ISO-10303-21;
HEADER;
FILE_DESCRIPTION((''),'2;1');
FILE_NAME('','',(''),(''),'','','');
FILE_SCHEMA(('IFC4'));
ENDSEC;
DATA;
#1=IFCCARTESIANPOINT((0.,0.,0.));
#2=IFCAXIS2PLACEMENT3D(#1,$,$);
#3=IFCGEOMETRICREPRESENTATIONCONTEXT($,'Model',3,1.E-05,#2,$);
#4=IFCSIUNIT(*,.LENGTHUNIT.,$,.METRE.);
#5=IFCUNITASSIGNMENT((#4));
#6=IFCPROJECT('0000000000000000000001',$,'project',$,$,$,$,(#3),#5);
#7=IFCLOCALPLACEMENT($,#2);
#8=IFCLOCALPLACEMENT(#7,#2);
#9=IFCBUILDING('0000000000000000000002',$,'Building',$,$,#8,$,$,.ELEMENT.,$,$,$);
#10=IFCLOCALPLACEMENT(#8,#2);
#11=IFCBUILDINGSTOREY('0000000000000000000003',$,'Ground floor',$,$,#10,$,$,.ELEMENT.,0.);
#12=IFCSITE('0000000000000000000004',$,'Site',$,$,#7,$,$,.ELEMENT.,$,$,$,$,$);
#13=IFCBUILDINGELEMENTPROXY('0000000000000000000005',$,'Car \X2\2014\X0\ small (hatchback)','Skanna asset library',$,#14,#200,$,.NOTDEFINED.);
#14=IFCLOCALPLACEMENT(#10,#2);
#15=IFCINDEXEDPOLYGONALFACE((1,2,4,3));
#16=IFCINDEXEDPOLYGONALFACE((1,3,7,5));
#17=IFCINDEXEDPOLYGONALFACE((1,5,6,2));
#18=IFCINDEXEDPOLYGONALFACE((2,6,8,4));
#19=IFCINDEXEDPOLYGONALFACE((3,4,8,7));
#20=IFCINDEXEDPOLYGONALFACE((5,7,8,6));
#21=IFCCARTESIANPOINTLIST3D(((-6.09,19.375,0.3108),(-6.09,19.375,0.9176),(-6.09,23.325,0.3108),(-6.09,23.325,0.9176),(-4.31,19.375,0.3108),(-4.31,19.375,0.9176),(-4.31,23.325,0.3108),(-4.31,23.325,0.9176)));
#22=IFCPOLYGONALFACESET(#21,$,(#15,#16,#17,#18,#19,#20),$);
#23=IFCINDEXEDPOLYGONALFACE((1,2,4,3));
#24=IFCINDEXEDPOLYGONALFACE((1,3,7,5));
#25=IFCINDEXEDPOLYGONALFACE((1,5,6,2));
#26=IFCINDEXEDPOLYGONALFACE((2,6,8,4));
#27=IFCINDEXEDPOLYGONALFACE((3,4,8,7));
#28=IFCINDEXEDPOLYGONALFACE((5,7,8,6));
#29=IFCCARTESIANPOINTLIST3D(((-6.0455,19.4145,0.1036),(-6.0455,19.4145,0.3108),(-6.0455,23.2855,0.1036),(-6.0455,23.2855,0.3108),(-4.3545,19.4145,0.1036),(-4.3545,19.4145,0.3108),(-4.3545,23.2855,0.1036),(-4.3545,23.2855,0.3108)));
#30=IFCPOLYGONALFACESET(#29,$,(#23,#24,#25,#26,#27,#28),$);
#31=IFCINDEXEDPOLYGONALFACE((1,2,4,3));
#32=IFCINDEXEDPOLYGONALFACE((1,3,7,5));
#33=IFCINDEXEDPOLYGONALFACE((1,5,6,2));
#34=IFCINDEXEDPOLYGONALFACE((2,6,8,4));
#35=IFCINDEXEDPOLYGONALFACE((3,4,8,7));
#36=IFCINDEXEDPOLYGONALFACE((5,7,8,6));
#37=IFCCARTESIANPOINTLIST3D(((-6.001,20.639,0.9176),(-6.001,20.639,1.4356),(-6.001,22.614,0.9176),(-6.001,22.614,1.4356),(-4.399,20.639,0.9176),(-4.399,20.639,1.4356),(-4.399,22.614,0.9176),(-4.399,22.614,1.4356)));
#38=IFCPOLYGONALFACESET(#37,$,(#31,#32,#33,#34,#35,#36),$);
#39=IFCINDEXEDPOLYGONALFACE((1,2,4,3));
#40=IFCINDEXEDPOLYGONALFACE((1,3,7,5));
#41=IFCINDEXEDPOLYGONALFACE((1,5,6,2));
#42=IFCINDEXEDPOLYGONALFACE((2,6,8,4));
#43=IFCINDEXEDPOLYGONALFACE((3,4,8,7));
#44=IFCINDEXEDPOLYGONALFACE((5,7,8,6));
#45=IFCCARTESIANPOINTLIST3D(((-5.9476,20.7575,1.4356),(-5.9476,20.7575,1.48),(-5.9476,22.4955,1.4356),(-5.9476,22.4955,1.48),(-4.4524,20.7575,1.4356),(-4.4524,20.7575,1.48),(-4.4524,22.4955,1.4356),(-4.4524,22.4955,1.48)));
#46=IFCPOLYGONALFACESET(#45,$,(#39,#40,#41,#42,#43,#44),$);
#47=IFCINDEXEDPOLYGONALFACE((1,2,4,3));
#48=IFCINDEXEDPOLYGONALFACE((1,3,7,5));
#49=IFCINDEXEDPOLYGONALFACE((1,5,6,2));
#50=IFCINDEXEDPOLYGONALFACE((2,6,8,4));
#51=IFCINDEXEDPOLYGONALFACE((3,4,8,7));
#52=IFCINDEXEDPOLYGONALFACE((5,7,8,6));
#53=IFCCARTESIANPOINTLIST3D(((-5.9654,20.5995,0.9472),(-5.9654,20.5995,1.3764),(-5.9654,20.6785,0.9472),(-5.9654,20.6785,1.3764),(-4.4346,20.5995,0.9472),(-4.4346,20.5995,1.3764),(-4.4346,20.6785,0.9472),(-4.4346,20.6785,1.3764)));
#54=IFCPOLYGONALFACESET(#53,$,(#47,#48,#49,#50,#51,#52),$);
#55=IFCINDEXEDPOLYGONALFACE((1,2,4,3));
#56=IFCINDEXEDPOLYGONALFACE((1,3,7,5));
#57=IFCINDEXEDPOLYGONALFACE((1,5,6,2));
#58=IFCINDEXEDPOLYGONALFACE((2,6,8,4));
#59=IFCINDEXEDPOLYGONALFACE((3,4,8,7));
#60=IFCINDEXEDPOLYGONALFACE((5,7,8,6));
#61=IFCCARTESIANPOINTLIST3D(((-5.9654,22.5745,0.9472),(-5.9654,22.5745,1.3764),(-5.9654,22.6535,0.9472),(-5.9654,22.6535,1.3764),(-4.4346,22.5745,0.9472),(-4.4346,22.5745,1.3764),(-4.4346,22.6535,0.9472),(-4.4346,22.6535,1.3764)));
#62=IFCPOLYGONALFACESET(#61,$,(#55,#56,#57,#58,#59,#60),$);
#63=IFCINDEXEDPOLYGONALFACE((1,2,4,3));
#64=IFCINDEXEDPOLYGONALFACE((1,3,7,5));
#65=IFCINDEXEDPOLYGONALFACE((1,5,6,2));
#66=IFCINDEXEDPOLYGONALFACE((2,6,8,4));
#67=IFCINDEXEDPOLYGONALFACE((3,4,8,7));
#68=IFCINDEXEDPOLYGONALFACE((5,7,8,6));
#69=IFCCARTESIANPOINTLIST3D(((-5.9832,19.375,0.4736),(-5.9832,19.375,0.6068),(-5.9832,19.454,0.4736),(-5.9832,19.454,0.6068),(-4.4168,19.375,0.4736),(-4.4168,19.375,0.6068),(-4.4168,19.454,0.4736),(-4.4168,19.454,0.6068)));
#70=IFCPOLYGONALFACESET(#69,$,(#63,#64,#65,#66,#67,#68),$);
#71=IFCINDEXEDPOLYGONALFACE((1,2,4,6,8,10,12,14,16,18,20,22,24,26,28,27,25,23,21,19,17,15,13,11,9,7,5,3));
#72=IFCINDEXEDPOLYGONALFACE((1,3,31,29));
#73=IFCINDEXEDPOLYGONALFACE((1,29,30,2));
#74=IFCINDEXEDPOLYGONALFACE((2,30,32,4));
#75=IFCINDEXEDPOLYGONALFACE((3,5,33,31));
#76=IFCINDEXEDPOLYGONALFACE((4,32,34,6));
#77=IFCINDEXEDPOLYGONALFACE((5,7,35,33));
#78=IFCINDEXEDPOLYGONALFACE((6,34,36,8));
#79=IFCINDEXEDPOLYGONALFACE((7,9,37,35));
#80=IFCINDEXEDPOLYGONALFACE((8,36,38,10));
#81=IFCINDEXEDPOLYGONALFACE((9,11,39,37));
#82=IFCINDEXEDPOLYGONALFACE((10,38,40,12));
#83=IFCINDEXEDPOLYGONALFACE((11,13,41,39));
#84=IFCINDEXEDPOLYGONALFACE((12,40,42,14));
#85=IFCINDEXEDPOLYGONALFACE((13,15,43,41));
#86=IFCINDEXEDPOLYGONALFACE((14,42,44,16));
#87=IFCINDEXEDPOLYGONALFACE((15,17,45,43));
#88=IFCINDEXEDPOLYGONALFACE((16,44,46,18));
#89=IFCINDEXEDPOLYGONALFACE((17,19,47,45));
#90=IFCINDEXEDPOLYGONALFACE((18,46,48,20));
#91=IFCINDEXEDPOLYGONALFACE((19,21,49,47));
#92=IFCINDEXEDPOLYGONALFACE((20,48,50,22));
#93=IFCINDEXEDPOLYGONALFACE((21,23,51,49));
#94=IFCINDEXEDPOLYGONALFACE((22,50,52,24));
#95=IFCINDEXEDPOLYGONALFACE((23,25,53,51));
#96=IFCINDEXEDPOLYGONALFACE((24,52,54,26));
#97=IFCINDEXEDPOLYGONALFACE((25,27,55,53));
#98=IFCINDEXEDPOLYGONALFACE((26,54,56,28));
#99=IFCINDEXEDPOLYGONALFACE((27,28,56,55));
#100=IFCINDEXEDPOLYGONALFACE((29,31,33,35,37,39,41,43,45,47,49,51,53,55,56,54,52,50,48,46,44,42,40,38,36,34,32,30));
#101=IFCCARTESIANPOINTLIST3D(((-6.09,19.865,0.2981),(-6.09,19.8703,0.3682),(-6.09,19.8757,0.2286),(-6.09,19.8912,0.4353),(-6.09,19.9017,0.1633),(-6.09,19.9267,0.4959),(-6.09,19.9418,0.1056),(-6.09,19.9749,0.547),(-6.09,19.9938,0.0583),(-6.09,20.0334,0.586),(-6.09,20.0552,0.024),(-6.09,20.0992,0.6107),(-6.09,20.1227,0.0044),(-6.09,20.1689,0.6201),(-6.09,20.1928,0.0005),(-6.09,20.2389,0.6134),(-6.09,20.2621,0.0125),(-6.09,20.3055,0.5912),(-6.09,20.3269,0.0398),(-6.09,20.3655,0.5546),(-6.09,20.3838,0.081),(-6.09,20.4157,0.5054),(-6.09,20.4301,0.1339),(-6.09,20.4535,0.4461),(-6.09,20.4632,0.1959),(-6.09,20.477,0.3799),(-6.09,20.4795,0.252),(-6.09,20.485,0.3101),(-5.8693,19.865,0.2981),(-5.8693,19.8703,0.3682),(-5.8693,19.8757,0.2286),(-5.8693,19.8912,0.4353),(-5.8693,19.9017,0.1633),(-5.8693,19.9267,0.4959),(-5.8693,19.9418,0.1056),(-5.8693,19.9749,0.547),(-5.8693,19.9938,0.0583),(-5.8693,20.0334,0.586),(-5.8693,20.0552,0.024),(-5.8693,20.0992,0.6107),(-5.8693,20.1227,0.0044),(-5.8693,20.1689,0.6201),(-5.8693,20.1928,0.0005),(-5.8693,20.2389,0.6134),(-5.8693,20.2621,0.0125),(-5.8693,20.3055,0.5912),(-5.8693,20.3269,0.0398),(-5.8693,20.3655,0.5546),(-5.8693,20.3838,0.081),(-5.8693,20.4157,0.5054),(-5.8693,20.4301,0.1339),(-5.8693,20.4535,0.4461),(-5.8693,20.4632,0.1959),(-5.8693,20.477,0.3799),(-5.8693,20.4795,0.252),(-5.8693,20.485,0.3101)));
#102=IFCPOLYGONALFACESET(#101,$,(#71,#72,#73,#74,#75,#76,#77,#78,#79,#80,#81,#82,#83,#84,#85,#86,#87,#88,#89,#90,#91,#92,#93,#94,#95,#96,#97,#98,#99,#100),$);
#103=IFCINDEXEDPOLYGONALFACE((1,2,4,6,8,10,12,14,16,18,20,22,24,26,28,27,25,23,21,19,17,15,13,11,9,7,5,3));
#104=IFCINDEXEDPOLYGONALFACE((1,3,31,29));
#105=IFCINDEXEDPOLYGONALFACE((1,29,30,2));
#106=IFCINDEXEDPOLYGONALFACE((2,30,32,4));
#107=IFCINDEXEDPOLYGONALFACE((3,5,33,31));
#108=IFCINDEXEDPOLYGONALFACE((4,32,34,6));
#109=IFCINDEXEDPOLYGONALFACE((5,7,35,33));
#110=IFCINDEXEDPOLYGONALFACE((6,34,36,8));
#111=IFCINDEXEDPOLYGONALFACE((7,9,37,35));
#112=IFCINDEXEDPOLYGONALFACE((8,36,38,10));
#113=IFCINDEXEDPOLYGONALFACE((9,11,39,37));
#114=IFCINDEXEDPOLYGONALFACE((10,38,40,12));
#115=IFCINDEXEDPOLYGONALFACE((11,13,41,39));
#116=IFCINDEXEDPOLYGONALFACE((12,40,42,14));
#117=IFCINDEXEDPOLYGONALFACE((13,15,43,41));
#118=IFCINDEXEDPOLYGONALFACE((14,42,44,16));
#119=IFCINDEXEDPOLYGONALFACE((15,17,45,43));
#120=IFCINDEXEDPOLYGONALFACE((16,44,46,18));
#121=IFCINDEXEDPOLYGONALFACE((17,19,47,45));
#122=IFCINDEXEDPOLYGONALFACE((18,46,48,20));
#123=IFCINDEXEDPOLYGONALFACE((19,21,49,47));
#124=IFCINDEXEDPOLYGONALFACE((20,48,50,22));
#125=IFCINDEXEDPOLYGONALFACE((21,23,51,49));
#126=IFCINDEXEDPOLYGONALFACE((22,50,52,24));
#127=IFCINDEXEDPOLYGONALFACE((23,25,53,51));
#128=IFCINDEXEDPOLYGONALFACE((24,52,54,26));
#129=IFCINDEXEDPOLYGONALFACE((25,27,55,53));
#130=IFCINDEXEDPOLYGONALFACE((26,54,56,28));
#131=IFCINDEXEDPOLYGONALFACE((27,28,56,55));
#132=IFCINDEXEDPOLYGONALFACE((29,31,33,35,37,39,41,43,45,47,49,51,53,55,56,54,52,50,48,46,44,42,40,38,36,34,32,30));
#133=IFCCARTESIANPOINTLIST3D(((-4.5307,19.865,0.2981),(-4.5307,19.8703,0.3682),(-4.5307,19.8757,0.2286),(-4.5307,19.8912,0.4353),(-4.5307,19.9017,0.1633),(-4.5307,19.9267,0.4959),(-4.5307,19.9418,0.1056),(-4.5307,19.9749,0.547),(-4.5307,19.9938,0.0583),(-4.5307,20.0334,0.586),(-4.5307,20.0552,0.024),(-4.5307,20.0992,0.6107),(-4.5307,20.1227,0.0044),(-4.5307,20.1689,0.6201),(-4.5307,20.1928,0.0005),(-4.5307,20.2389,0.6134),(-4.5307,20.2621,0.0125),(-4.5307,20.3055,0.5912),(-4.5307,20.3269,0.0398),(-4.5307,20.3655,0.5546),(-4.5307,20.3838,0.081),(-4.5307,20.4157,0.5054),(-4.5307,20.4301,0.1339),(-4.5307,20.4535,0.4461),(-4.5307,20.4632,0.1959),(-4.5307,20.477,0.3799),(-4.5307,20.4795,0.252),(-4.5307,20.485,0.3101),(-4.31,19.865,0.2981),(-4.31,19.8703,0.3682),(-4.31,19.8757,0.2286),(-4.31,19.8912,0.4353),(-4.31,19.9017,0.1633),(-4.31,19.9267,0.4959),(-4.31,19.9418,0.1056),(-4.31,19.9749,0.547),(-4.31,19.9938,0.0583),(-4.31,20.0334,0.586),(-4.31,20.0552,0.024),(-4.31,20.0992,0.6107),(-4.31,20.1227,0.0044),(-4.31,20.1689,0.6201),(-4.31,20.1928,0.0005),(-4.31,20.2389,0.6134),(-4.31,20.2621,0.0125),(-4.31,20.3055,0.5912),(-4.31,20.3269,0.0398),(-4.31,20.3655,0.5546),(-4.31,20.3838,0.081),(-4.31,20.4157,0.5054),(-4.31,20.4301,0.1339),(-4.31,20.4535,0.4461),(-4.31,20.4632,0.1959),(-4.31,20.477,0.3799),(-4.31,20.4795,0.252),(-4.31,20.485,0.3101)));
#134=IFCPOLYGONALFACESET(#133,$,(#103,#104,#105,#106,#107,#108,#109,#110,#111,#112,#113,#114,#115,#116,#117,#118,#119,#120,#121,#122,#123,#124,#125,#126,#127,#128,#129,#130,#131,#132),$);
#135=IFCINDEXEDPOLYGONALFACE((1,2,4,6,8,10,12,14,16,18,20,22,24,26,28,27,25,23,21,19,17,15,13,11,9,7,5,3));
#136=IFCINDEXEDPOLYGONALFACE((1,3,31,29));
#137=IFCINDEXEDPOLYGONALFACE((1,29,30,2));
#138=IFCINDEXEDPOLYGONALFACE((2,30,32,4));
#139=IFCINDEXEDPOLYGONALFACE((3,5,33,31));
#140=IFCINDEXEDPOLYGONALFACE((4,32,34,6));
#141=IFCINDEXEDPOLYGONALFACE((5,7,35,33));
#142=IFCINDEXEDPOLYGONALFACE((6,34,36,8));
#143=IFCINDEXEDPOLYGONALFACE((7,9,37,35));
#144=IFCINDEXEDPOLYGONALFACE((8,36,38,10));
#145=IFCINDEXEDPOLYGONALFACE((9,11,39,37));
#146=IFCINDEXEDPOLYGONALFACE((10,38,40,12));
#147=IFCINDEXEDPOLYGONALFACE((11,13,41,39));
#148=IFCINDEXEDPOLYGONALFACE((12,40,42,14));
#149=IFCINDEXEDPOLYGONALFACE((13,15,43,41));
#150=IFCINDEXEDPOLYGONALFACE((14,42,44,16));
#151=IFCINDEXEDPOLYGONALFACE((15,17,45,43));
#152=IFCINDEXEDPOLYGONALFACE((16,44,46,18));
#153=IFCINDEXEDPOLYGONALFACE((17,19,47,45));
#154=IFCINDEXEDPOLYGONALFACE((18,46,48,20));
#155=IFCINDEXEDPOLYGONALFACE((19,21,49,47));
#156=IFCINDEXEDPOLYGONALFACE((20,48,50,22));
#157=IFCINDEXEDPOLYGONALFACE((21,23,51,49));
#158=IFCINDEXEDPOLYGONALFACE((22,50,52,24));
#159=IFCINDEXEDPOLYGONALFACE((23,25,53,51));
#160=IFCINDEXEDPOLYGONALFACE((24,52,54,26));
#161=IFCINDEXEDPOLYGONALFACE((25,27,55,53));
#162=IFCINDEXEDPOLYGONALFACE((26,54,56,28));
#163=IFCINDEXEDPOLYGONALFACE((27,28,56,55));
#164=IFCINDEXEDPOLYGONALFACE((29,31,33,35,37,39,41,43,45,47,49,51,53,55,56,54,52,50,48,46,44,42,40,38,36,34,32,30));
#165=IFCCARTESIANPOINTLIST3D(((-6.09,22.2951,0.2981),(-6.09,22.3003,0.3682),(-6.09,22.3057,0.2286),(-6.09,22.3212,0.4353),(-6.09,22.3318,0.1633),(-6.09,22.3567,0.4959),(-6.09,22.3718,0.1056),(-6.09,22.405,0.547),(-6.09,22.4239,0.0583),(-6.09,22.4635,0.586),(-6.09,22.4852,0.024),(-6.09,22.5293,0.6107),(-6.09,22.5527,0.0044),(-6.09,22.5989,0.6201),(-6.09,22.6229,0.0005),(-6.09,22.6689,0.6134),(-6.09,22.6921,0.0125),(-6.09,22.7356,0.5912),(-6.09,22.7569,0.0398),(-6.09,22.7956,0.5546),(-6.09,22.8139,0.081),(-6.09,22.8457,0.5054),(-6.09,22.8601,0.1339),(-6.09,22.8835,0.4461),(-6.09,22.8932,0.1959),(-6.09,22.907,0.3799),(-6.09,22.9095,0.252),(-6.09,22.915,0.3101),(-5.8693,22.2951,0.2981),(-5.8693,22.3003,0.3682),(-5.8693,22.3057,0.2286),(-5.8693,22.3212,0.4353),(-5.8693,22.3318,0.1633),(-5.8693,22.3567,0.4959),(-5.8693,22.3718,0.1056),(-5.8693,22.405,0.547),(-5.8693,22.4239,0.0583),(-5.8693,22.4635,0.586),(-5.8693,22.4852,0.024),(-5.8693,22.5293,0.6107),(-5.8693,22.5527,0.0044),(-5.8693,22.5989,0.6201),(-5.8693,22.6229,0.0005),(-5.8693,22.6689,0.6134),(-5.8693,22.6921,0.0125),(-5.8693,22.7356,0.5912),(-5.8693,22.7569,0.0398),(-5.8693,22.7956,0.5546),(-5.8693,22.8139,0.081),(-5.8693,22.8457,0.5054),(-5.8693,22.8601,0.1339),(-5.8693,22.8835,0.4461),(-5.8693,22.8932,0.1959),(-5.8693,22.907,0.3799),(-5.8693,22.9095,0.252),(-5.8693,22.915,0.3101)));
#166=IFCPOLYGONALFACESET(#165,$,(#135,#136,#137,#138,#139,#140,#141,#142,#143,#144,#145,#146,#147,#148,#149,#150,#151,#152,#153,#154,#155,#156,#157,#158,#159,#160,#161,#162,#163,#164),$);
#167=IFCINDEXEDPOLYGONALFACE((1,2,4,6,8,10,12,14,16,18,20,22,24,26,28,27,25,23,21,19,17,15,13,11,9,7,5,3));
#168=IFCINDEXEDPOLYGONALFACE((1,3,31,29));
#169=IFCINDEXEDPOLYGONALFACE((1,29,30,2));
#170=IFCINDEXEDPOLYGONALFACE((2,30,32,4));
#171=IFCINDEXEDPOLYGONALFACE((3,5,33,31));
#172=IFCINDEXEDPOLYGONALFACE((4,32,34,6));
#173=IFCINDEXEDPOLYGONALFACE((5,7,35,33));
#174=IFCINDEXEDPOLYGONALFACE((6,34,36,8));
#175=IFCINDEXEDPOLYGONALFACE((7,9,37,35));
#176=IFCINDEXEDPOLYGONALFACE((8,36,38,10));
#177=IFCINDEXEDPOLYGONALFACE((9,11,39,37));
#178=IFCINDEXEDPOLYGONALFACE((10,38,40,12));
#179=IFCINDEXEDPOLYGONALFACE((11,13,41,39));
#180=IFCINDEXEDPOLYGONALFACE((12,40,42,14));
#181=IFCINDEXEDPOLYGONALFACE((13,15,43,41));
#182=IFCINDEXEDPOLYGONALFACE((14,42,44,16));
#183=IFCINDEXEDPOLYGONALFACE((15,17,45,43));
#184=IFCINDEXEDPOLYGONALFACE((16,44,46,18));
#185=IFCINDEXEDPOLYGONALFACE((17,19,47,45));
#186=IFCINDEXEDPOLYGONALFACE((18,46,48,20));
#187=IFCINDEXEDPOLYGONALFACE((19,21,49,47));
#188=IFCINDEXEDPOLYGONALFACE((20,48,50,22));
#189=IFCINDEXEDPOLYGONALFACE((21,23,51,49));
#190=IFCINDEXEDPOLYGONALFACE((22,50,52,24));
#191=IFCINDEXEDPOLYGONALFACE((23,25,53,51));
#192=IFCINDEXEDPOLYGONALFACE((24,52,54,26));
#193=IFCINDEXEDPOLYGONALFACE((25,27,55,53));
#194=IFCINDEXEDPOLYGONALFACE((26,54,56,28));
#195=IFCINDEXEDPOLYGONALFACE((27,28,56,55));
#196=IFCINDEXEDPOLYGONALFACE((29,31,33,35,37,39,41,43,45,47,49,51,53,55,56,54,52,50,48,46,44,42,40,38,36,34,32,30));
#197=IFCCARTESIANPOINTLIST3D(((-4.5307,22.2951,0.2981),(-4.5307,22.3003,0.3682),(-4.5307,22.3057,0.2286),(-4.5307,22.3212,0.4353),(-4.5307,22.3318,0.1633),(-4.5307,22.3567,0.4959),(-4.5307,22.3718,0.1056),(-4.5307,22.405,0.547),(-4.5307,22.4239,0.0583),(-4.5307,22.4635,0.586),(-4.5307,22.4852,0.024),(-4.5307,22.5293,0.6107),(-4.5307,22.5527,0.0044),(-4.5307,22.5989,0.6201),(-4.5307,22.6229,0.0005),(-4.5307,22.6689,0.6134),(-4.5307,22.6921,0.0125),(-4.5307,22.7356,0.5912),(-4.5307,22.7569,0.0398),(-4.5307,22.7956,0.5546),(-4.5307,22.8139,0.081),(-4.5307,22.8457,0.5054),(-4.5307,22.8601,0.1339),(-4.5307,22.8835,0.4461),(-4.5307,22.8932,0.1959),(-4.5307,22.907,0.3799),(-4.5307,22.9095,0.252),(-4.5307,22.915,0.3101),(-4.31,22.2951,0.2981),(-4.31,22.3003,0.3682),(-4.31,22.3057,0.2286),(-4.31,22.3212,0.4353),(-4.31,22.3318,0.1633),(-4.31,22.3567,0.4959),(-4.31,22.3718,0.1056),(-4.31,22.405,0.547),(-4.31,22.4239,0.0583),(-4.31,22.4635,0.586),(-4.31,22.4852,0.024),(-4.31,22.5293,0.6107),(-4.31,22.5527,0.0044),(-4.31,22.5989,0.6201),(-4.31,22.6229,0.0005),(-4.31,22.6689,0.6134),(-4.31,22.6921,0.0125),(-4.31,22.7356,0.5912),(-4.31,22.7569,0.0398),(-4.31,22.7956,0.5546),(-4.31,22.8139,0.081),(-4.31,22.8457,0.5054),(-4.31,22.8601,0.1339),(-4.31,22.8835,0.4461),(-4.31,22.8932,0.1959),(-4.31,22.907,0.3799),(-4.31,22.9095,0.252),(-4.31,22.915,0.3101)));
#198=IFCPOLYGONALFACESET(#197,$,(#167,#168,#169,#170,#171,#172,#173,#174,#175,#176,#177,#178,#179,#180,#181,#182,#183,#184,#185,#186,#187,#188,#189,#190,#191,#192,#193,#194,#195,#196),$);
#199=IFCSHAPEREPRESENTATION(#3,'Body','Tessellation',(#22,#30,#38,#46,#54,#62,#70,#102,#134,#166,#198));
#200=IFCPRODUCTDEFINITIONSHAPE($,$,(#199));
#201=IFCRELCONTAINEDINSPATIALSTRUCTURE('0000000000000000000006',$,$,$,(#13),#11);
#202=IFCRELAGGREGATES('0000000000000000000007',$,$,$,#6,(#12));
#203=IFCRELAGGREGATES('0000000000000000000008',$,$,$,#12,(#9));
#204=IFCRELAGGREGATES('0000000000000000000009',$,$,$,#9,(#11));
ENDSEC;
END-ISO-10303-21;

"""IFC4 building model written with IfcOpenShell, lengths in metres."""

from ifc_helpers import new_model, si_unit, frame, frame_2d, origin, origin_2d, place, context, project, spatial, rectangle, ellipse, extrude, element, save


model = new_model("IFC4")

# Units and contexts
model_context = context("Model", 3, precision=1e-05, world=origin())
ifc_project = project(units=[si_unit("LENGTHUNIT", "METRE")], contexts=[model_context])

# Site, building, storey
site_placement = place(None, origin())
site = spatial("IfcSite", under=ifc_project, at=site_placement, Name="Site", CompositionType="ELEMENT")
building_placement = place(site_placement, origin())
building = spatial("IfcBuilding", under=site, at=building_placement, Name="Building", CompositionType="ELEMENT")
storey_placement = place(building_placement, origin())
storey = spatial("IfcBuildingStorey", under=building, at=storey_placement, Name="Ground floor", CompositionType="ELEMENT", Elevation=0.0)

# Building element proxy
proxy_1_placement = place(storey_placement, frame((-5.2, 21.35, 0.0), z_axis=(0.0, 0.0, 1.0), x_axis=(1.0, 0.0, 0.0)))
element("IfcBuildingElementProxy", 1, at=proxy_1_placement, inside=storey, Name="Car — small (hatchback)", Description="Skanna asset library", PredefinedType="NOTDEFINED", context=model_context, shape_type="SweptSolid", body=[
    extrude(rectangle(XDim=1.78, YDim=3.95, at=origin_2d()), frame((0.0, 0.0, 0.3108)), (0.0, 0.0, 1.0), 0.6068),
    extrude(rectangle(XDim=1.691, YDim=3.871, at=origin_2d()), frame((0.0, 0.0, 0.1036)), (0.0, 0.0, 1.0), 0.2072),
    extrude(rectangle(XDim=1.602, YDim=1.975, at=frame_2d((0.0, 0.2765))), frame((0.0, 0.0, 0.9176)), (0.0, 0.0, 1.0), 0.518),
    extrude(rectangle(XDim=1.4952, YDim=1.738, at=frame_2d((0.0, 0.2765))), frame((0.0, 0.0, 1.4356)), (0.0, 0.0, 1.0), 0.0444),
    extrude(rectangle(XDim=1.5308, YDim=0.079, at=frame_2d((0.0, -0.711))), frame((0.0, 0.0, 0.9472)), (0.0, 0.0, 1.0), 0.4292),
    extrude(rectangle(XDim=1.5308, YDim=0.079, at=frame_2d((0.0, 1.264))), frame((0.0, 0.0, 0.9472)), (0.0, 0.0, 1.0), 0.4292),
    extrude(rectangle(XDim=1.5664, YDim=0.079, at=frame_2d((0.0, -1.9355))), frame((0.0, 0.0, 0.4736)), (0.0, 0.0, 1.0), 0.1332),
    extrude(ellipse(SemiAxis1=0.3101, SemiAxis2=0.3101, at=origin_2d()), frame((-0.89, -1.1751, 0.3101), z_axis=(1.0, 0.0, 0.0), x_axis=(0.0, 1.0, 0.0)), (0.0, 0.0, 1.0), 0.2207),
    extrude(ellipse(SemiAxis1=0.3101, SemiAxis2=0.3101, at=origin_2d()), frame((0.6693, -1.1751, 0.3101), z_axis=(1.0, 0.0, 0.0), x_axis=(0.0, 1.0, 0.0)), (0.0, 0.0, 1.0), 0.2207),
    extrude(ellipse(SemiAxis1=0.3101, SemiAxis2=0.3101, at=origin_2d()), frame((-0.89, 1.2549, 0.3101), z_axis=(1.0, 0.0, 0.0), x_axis=(0.0, 1.0, 0.0)), (0.0, 0.0, 1.0), 0.2207),
    extrude(ellipse(SemiAxis1=0.3101, SemiAxis2=0.3101, at=origin_2d()), frame((0.6693, 1.2549, 0.3101), z_axis=(1.0, 0.0, 0.0), x_axis=(0.0, 1.0, 0.0)), (0.0, 0.0, 1.0), 0.2207),
])

save(model, "model.ifc")
